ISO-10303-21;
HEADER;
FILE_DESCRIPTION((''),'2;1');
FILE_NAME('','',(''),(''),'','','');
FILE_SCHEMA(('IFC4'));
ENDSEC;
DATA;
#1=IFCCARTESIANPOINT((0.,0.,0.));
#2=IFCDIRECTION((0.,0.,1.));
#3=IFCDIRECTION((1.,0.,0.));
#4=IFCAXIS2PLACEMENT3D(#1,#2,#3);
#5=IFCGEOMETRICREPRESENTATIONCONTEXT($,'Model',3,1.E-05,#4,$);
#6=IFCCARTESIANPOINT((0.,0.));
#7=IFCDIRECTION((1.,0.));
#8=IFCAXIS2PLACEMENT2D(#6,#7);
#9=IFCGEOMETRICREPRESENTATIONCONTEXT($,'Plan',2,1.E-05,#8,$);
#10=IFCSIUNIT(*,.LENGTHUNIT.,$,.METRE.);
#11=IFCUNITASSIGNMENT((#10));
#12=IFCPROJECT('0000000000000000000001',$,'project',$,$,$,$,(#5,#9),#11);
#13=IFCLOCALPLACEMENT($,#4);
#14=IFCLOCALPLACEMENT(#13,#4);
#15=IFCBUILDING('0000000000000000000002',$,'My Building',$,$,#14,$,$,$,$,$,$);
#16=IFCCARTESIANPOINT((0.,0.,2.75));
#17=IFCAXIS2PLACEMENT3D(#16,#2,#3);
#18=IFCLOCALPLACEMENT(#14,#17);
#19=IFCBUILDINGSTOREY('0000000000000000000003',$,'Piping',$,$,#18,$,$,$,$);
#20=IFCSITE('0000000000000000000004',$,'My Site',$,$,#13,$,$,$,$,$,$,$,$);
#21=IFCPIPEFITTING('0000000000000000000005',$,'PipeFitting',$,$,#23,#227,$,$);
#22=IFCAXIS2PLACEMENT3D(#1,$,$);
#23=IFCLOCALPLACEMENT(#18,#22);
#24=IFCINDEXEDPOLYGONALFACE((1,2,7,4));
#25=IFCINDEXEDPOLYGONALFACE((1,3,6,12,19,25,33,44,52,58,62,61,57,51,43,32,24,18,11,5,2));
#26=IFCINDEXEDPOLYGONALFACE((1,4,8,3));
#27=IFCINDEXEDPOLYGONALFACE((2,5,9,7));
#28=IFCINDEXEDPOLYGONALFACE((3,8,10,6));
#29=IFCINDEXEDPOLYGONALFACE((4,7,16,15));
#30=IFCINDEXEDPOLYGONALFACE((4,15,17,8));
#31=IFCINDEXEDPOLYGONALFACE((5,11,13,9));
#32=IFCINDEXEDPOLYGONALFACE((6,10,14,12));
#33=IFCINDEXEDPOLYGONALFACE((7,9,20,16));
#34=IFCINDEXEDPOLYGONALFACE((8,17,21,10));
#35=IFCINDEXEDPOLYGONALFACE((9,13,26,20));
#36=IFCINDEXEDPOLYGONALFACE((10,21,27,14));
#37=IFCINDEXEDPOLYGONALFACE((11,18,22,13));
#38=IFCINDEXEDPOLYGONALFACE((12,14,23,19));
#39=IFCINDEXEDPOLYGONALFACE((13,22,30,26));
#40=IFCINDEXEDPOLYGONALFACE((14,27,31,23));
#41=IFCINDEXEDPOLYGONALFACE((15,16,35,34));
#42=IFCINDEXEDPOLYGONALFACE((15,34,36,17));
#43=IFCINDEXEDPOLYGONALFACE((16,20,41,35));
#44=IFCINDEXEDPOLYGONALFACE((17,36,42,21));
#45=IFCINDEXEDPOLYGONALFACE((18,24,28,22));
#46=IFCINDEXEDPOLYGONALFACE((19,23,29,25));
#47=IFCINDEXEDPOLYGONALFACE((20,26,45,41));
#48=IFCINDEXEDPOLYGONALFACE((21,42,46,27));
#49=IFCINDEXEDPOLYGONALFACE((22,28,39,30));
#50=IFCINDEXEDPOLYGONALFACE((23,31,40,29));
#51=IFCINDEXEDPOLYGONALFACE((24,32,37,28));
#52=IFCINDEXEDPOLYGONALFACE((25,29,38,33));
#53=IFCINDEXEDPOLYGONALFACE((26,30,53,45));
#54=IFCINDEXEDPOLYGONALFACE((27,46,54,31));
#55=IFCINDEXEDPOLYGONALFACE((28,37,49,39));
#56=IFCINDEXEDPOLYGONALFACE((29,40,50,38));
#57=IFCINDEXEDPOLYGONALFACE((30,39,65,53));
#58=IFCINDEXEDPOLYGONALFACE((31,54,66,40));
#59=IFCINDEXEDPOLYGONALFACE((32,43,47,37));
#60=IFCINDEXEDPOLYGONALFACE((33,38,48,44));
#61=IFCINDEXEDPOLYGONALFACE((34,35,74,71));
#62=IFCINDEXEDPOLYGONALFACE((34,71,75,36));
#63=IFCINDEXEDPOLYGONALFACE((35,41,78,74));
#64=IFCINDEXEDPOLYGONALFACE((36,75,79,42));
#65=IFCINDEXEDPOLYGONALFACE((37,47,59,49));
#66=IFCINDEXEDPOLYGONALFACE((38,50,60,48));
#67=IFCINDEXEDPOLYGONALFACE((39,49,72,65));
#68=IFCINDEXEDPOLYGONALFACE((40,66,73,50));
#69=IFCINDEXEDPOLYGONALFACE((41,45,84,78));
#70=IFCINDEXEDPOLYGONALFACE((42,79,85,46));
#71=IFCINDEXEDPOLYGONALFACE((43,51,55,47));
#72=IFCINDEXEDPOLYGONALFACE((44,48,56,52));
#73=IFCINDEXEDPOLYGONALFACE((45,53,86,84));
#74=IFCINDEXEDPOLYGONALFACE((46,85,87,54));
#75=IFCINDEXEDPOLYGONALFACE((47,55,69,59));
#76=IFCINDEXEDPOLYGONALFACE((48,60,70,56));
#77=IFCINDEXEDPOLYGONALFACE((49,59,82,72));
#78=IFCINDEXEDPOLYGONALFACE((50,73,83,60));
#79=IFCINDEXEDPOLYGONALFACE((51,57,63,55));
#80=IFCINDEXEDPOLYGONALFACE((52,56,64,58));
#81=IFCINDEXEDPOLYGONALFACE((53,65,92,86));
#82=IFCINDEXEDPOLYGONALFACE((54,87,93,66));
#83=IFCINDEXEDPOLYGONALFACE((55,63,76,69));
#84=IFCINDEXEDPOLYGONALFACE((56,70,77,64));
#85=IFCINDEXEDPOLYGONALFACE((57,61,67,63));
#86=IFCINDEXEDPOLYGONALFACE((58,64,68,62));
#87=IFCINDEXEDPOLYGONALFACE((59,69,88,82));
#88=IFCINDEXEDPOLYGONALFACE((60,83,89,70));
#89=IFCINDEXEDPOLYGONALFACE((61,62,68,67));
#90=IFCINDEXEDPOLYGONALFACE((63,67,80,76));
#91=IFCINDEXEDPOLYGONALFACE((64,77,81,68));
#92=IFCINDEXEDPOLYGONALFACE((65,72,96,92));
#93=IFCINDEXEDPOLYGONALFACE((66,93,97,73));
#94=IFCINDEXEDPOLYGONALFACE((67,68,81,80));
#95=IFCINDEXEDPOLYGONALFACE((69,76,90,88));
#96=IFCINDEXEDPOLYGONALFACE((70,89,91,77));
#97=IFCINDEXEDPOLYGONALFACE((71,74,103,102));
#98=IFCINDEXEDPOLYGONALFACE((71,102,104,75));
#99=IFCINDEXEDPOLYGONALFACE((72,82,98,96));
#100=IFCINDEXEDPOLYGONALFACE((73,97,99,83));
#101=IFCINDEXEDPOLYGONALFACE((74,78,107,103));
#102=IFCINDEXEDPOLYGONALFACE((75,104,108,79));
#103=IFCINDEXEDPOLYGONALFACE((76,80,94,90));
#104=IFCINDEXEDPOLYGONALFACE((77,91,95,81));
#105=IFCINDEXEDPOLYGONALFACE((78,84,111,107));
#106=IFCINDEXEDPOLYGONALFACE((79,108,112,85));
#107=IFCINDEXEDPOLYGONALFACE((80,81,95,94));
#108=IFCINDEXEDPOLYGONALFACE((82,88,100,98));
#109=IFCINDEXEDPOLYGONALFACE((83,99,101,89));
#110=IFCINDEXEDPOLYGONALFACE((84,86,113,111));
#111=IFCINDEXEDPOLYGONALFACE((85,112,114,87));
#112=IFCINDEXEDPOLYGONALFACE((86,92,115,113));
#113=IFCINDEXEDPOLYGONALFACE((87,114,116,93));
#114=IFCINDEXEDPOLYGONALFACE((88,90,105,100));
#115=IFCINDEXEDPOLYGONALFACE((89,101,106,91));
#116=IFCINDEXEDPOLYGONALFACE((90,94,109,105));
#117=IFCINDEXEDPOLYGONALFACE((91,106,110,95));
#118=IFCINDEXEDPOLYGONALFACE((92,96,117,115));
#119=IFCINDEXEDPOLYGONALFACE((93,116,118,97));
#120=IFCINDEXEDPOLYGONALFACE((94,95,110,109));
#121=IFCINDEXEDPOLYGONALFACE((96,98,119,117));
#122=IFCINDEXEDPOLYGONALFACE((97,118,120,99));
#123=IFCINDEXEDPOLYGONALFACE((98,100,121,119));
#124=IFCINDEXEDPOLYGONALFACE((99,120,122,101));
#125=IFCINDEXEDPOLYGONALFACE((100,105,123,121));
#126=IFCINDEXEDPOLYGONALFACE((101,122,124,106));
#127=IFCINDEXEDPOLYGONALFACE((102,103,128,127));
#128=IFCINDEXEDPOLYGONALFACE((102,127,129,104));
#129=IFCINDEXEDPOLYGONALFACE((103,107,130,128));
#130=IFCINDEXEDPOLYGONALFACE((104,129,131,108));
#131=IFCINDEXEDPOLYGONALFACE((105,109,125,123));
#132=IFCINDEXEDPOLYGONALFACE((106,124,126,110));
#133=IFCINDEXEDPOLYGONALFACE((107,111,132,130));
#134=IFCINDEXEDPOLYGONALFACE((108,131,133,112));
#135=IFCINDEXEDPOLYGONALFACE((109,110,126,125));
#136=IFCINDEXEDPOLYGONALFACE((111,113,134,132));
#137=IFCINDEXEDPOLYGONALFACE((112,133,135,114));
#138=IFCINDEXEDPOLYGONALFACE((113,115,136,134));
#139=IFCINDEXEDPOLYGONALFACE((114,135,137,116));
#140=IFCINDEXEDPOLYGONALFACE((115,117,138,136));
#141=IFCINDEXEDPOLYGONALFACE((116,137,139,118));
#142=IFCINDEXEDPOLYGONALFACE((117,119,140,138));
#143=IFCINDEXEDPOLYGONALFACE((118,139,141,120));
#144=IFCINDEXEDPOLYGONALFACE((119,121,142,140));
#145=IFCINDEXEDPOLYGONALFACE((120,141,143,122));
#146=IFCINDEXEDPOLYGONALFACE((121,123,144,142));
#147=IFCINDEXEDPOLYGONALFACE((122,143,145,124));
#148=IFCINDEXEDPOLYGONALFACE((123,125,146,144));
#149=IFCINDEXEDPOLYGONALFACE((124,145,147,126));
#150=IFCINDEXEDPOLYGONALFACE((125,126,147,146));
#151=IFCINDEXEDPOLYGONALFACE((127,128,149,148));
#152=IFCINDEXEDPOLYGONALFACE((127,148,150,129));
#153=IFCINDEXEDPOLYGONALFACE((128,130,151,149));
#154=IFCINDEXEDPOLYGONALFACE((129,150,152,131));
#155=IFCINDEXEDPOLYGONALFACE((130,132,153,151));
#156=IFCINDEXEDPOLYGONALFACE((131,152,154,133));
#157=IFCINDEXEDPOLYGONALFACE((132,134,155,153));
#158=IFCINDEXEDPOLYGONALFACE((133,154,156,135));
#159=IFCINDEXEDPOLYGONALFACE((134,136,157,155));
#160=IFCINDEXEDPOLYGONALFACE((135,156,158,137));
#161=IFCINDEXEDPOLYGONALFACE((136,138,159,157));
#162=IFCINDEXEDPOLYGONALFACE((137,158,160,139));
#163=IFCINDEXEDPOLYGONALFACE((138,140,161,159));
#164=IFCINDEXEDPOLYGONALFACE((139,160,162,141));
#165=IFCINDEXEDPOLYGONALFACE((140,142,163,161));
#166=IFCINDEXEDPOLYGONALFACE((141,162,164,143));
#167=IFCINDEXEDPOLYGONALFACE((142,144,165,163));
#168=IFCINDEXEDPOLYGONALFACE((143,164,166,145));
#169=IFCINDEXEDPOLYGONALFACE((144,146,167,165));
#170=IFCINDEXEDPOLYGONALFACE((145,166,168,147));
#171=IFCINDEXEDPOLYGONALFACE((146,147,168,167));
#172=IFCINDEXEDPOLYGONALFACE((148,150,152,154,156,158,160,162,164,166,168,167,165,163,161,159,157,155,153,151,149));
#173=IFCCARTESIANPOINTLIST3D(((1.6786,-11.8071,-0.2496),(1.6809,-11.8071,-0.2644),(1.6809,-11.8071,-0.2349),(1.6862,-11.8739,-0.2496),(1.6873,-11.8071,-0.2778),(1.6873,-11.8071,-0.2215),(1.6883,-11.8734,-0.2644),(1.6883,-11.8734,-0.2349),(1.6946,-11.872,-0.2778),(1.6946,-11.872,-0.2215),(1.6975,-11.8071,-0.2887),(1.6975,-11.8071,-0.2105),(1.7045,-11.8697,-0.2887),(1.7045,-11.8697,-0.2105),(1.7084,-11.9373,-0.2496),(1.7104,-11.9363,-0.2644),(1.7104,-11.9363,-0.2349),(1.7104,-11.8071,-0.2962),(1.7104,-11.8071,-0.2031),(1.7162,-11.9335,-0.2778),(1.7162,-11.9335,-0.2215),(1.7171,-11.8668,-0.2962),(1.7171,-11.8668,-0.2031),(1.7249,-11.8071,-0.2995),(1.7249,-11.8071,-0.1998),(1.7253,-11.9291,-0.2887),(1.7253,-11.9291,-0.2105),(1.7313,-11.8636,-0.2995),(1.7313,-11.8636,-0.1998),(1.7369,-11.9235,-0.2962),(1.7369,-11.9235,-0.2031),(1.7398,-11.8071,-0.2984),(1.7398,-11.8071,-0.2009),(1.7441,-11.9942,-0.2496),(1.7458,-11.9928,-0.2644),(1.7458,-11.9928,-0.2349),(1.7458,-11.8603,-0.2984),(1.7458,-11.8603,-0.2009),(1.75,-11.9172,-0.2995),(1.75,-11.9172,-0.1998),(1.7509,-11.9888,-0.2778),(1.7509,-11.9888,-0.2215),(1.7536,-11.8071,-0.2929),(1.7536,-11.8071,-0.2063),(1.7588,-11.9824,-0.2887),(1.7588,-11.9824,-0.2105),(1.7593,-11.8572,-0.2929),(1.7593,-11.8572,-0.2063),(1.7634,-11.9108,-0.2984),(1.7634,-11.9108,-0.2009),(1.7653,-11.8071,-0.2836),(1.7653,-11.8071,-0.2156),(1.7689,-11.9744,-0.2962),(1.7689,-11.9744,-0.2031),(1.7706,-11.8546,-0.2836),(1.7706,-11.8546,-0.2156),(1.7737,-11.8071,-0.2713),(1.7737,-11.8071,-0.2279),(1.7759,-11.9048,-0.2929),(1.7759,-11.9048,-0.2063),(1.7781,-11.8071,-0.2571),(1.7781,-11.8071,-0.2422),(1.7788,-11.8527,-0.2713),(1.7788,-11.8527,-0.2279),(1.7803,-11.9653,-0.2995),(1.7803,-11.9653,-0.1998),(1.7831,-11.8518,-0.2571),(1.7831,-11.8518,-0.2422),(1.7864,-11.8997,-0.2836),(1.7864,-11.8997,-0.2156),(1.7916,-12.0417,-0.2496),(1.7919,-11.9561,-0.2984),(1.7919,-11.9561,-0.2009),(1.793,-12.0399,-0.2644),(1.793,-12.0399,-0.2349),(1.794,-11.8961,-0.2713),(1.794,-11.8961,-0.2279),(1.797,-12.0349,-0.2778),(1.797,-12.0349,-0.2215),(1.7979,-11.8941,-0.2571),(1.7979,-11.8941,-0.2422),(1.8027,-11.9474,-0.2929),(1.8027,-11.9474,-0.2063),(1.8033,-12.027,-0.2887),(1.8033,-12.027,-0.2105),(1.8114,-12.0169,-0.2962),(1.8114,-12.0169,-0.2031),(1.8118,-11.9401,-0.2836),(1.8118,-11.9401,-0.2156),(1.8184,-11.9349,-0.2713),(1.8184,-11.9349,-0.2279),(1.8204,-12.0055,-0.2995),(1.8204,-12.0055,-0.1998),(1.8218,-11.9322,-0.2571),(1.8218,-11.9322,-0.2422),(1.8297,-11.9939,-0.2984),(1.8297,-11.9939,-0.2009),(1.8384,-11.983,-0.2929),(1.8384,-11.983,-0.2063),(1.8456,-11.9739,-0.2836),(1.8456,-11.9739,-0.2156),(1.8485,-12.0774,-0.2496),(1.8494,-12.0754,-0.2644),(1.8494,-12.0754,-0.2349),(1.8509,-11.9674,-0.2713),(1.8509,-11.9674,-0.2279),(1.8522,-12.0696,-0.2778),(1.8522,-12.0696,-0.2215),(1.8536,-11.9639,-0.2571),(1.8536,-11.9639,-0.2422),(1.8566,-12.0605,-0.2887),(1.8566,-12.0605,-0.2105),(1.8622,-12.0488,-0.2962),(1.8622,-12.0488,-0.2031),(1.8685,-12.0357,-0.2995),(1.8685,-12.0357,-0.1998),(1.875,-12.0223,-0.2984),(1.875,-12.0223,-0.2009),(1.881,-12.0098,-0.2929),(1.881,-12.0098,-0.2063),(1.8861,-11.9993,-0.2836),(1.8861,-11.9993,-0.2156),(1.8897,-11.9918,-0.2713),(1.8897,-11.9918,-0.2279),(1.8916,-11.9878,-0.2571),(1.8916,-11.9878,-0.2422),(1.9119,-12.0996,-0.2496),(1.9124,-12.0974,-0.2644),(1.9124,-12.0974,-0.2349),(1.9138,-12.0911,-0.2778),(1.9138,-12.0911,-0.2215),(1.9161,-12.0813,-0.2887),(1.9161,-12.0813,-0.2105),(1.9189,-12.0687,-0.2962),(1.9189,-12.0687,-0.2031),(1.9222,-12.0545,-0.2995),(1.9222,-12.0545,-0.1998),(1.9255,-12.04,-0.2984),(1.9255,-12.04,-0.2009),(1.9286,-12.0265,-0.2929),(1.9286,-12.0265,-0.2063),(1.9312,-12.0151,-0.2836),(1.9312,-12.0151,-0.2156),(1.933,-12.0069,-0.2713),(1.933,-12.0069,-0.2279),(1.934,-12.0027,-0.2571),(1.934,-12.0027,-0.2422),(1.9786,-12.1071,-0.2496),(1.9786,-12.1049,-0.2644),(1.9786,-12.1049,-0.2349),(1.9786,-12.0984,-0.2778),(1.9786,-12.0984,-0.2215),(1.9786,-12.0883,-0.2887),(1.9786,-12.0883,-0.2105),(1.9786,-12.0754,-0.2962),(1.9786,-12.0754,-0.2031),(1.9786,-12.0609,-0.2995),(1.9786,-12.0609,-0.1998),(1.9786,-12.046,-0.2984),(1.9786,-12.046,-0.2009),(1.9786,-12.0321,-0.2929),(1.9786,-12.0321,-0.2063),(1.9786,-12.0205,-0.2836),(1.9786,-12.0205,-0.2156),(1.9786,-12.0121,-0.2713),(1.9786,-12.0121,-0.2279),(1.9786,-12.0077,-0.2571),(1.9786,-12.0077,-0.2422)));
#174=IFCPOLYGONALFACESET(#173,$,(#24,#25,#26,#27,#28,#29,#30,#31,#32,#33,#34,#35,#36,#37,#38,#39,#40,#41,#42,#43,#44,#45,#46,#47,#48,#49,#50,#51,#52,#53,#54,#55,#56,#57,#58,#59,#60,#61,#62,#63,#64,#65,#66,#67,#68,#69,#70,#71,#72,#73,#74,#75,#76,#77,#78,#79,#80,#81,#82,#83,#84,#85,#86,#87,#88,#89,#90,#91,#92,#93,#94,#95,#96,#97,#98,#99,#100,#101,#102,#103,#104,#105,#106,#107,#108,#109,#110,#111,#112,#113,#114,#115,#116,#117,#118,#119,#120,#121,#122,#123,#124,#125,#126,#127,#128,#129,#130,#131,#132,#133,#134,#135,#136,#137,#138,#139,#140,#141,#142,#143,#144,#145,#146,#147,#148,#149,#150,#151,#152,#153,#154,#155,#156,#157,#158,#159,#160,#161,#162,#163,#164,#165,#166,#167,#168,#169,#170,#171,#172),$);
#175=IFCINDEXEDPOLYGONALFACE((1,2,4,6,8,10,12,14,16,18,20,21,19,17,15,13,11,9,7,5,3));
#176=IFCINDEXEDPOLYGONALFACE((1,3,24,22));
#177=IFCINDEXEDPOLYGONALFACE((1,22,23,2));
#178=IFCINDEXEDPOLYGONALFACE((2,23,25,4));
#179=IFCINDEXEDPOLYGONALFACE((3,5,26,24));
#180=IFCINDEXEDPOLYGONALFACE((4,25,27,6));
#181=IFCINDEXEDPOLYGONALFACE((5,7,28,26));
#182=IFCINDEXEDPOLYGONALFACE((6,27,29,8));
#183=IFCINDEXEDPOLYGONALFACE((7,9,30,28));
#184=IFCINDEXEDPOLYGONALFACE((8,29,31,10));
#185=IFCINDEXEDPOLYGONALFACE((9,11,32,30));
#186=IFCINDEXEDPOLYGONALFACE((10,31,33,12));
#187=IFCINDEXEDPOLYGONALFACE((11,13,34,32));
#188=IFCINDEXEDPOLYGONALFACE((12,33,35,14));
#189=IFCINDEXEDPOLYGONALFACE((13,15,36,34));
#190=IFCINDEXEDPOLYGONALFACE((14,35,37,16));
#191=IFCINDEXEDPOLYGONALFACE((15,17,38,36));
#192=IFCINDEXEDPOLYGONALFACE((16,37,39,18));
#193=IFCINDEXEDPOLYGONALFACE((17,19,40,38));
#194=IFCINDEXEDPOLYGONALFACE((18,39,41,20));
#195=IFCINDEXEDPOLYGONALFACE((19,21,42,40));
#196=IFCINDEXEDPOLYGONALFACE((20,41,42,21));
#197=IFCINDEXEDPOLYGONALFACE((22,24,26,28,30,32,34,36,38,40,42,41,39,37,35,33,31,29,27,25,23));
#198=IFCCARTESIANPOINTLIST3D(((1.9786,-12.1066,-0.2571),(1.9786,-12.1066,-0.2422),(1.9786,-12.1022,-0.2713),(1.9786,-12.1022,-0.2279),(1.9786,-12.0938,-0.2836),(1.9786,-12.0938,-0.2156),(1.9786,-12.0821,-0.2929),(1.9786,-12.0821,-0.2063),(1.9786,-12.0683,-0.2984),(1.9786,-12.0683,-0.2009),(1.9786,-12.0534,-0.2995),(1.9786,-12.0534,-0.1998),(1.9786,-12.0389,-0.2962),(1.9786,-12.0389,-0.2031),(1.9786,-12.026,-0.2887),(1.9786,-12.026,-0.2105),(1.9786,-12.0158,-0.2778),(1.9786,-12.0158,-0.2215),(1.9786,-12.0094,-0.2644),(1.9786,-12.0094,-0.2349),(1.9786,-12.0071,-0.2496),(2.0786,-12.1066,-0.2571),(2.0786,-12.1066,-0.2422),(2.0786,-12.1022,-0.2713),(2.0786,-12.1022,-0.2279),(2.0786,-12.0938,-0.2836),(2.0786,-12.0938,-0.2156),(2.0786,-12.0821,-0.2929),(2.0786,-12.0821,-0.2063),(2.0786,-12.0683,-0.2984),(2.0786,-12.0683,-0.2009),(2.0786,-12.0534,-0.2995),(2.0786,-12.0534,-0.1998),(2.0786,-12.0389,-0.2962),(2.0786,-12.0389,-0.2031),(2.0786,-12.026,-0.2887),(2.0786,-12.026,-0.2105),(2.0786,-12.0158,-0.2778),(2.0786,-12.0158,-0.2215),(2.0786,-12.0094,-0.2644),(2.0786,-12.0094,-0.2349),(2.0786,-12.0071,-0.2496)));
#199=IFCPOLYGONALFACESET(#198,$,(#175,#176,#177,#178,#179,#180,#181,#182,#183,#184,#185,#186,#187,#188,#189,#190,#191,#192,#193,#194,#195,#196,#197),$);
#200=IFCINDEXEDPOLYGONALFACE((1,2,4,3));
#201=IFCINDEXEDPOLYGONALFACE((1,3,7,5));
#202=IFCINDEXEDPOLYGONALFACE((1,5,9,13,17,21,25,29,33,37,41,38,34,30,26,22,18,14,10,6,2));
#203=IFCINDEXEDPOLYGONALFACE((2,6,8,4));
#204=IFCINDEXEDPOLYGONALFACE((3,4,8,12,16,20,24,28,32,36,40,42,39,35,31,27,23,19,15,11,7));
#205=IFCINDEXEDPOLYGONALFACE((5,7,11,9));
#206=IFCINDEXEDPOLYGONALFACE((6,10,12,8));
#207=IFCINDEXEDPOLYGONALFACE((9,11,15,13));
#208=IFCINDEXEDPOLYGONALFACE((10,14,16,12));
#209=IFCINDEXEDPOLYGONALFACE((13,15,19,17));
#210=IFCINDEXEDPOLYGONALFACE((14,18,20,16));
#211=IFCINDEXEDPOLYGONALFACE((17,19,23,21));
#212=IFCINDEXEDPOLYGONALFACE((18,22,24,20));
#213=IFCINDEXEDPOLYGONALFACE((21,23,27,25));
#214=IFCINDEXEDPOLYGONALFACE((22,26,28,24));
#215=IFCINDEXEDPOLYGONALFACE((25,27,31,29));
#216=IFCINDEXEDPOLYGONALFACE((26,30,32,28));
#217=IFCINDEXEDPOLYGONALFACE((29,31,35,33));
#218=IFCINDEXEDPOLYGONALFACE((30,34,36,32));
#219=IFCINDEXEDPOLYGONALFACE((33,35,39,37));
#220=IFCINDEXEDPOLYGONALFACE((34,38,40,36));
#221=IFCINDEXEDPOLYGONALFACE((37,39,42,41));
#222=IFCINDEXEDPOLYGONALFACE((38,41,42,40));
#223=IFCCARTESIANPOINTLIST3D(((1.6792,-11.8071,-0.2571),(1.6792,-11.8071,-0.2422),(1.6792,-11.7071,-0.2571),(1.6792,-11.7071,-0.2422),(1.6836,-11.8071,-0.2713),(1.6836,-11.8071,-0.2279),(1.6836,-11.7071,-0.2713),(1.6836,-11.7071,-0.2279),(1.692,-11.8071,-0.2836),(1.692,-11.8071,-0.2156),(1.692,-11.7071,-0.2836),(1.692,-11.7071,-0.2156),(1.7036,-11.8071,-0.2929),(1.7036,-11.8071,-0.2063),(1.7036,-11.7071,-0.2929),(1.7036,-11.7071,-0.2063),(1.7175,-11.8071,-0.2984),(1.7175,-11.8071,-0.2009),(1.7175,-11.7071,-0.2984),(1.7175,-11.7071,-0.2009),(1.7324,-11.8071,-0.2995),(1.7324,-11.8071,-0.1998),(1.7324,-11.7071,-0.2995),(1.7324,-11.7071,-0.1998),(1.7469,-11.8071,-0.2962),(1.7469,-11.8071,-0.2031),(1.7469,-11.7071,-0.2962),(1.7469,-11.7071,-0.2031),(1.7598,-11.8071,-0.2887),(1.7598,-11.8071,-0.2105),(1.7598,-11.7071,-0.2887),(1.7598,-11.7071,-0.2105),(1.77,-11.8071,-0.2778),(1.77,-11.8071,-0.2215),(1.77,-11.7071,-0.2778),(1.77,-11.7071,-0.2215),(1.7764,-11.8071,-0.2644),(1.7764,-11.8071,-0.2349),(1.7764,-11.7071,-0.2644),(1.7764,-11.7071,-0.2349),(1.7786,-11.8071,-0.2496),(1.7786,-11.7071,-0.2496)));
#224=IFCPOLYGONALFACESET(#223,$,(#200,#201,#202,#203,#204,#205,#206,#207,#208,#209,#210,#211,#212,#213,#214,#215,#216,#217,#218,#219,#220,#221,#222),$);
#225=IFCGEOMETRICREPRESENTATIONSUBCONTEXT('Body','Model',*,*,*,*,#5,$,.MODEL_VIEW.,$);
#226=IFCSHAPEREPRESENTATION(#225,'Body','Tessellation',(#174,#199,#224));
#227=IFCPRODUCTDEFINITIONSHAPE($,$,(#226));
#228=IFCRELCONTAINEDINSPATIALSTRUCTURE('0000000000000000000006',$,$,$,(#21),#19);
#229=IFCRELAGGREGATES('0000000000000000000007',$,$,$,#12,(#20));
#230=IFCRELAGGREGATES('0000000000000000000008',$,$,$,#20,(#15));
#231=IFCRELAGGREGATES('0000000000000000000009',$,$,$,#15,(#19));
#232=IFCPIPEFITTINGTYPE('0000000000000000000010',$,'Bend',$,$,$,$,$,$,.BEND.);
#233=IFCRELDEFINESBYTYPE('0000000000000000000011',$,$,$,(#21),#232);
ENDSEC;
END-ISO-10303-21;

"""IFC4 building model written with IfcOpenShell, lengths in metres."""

from ifc_helpers import new_model, entity, si_unit, frame, origin_with_axes, origin_2d_with_axis, place, context, subcontext, project, spatial, circle, extrude, source, transform, mapped, type_object, type_shapes, element, save


model = new_model("IFC4")

# Units and contexts
model_context = context("Model", 3, precision=1e-05, world=origin_with_axes())
plan_context = context("Plan", 2, precision=1e-05, world=origin_2d_with_axis())
body_context = subcontext(model_context, "Body", "Model", "MODEL_VIEW")
ifc_project = project(units=[si_unit("LENGTHUNIT", "METRE")], contexts=[model_context, plan_context])

# Site, building, storey
site_placement = place(None, origin_with_axes())
site = spatial("IfcSite", under=ifc_project, at=site_placement, Name="My Site")
building_placement = place(site_placement, origin_with_axes())
building = spatial("IfcBuilding", under=site, at=building_placement, Name="My Building")
storey_placement = place(building_placement, frame((0.0, 0.0, 2.75), z_axis=(0.0, 0.0, 1.0), x_axis=(1.0, 0.0, 0.0)))
storey = spatial("IfcBuildingStorey", under=building, at=storey_placement, Name="Piping")

# Pipe fitting
pipe_fitting_type = type_object("IfcPipeFittingType", Name="Bend", PredefinedType="BEND")
shared_shape = source(origin_with_axes(), body_context, "Body", "SolidModel", [
    entity("IfcSweptDiskSolid", entity("IfcIndexedPolyCurve", entity("IfcCartesianPointList3D", [[0.0, 0.0, -0.1], [0.0732, 0.0, -0.2768], [0.25, 0.0, -0.35]]), [entity("IfcArcIndex", [1, 2, 3])]), 0.05),
    extrude(circle(Radius=0.05), origin_with_axes(), (0.0, 0.0, -1.0), 0.1),
    extrude(circle(Radius=0.05), frame((0.25, 0.0, -0.35), z_axis=(1.0, 0.0, 0.0), x_axis=(0.0, 0.0, 1.0)), (0.0, 0.0, 1.0), 0.1),
])
type_shapes(pipe_fitting_type, [shared_shape])
for number, where, z_axis, x_axis, name in (
    (1, (2.0786, -12.0571, -0.2496), (1.0, 0.0, 0.0), (0.0, 1.0, 0.0), "PipeFitting"),
):
    element("IfcPipeFitting", number, at=place(storey_placement, frame(where, z_axis=z_axis, x_axis=x_axis)), inside=storey, type_object=pipe_fitting_type, Name=name, context=body_context, shape_type="MappedRepresentation", body=[
        mapped(shared_shape, transform((0.0, 0.0, 0.0), x_axis=(1.0, 0.0, 0.0), y_axis=(0.0, 1.0, 0.0), z_axis=(0.0, 0.0, 1.0), scale=1.0)),
    ])

save(model, "model.ifc")
